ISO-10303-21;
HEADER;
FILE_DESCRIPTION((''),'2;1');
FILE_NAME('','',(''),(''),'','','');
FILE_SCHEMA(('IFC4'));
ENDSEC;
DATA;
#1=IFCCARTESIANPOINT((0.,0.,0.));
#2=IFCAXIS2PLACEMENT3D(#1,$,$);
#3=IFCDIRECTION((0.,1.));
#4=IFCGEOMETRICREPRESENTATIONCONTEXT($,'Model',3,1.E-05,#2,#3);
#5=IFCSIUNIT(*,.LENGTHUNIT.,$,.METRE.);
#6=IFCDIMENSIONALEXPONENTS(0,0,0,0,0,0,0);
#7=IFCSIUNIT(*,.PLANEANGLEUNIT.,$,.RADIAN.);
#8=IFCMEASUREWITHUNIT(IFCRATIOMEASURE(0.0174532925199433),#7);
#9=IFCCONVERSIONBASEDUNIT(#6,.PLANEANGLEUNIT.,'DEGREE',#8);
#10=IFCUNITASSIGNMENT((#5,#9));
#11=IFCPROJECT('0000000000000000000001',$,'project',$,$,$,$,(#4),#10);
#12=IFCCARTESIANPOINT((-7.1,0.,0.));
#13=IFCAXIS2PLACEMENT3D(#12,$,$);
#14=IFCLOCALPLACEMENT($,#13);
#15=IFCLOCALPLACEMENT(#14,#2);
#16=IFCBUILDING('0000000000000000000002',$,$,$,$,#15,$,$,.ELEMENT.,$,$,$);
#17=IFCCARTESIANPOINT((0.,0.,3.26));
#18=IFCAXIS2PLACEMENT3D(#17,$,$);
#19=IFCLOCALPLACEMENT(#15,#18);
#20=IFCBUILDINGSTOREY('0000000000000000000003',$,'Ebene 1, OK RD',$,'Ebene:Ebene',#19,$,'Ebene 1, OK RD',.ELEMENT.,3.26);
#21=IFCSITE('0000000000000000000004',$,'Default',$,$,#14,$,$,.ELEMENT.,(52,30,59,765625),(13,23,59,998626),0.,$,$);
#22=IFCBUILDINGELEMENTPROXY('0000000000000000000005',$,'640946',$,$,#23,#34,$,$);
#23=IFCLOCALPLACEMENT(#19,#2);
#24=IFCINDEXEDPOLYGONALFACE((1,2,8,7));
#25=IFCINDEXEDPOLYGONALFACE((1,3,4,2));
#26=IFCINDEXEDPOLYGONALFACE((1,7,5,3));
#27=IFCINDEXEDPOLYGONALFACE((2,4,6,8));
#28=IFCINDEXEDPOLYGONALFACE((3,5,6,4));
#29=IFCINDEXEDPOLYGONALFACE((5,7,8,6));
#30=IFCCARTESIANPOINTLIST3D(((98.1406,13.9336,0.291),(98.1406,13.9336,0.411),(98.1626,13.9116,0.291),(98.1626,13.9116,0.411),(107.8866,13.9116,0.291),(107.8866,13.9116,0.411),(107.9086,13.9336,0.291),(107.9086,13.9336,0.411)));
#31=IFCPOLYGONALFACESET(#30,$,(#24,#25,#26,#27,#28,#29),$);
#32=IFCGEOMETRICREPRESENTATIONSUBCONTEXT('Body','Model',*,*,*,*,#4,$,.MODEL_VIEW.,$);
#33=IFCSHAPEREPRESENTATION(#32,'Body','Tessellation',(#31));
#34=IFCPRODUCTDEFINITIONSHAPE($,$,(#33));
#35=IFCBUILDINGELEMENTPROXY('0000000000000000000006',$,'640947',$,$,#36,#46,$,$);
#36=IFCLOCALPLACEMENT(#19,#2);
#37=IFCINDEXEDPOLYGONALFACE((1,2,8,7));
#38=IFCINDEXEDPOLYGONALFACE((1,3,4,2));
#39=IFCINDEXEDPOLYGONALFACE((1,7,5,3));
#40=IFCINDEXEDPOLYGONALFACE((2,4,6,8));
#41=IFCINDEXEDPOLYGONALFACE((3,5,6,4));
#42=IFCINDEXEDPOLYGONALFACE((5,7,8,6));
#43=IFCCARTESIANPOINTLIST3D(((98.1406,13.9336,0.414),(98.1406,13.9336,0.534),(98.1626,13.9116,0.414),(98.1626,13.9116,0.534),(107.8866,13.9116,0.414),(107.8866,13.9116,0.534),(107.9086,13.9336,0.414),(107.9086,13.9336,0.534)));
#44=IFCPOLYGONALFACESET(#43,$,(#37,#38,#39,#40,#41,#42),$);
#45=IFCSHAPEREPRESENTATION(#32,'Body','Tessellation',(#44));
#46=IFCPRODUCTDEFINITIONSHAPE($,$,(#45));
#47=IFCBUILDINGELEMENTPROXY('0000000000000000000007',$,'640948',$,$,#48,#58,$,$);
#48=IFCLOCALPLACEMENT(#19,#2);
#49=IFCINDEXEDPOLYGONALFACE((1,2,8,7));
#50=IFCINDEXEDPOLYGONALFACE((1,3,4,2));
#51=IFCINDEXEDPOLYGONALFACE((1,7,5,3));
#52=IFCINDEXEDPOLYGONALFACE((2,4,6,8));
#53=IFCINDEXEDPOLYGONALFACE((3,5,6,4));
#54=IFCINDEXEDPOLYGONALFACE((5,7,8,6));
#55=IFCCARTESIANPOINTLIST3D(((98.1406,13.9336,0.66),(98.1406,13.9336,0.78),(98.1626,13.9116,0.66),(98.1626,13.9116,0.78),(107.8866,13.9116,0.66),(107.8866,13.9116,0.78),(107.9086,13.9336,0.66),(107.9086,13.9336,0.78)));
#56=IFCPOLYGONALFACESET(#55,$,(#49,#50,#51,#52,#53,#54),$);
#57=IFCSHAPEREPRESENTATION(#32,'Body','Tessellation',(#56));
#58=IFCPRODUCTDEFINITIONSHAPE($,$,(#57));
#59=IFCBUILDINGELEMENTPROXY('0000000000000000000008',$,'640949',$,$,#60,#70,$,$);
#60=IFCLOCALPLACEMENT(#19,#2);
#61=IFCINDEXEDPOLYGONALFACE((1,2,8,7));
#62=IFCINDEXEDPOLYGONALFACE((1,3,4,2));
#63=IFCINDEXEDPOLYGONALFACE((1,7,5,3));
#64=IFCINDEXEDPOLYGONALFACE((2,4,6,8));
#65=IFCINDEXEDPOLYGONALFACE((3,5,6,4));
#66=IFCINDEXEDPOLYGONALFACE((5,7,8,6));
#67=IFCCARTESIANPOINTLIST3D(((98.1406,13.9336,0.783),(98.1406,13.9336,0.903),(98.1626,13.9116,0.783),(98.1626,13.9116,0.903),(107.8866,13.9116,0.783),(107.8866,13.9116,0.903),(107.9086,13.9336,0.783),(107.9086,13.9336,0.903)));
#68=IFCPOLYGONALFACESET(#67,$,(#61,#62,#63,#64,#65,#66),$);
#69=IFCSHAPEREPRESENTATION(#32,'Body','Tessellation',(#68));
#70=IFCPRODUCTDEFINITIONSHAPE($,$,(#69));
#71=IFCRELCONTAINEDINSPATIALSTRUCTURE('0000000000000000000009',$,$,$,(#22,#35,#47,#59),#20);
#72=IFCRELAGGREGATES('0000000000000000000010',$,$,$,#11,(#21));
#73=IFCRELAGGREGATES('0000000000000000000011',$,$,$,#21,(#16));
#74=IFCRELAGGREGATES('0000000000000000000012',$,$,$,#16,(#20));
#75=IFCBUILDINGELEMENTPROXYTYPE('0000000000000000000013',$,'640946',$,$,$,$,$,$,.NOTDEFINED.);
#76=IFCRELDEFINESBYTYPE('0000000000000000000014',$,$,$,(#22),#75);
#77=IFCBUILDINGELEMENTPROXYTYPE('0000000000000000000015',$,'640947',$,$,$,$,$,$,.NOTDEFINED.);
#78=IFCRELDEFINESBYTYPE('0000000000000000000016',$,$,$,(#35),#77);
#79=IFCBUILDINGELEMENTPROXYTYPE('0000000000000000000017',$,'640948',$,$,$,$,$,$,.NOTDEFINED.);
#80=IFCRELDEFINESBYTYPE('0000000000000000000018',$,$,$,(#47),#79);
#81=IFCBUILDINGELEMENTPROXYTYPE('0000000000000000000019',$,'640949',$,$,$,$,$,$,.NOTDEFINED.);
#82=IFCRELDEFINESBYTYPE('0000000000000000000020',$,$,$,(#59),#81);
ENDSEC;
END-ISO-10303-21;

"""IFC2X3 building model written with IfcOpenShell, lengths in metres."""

from ifc_helpers import new_model, entity, si_unit, converted_unit, direction, frame, origin, place, context, subcontext, project, spatial, polyline, outline, extrude, type_object, element, save


model = new_model("IFC2X3")

# Units and contexts
model_context = context("Model", 3, precision=1e-05, world=origin(), true_north=direction((0.0, 1.0)))
body_context = subcontext(model_context, "Body", "Model", "MODEL_VIEW")
ifc_project = project(units=[si_unit("LENGTHUNIT", "METRE"), converted_unit("PLANEANGLEUNIT", "DEGREE", entity("IfcRatioMeasure", 0.0174532925199433), si_unit("PLANEANGLEUNIT", "RADIAN"), dimensions=[0, 0, 0, 0, 0, 0, 0])], contexts=[model_context])

# Site, building, storey
site_placement = place(None, frame((-7.1, 0.0, 0.0)))
site = spatial("IfcSite", under=ifc_project, at=site_placement, Name="Default", CompositionType="ELEMENT", RefLatitude=(52, 30, 59, 765625), RefLongitude=(13, 23, 59, 998626), RefElevation=0.0)
building_placement = place(site_placement, origin())
building = spatial("IfcBuilding", under=site, at=building_placement, CompositionType="ELEMENT")
storey_placement = place(building_placement, frame((0.0, 0.0, 3.26)))
storey = spatial("IfcBuildingStorey", under=building, at=storey_placement, Name="Ebene 1, OK RD", ObjectType="Ebene:Ebene", LongName="Ebene 1, OK RD", CompositionType="ELEMENT", Elevation=3.26)

# Building element proxies
building_element_proxy_type_1 = type_object("IfcBuildingElementProxyType", Name="640946", PredefinedType="NOTDEFINED")
proxy_1_placement = place(storey_placement, origin())
element("IfcBuildingElementProxy", 1, at=proxy_1_placement, inside=storey, type_object=building_element_proxy_type_1, Name="640946", context=body_context, shape_type="SweptSolid", body=[
    extrude(outline(polyline([(-4.862, -0.011), (4.862, -0.011), (4.884, 0.011), (-4.884, 0.011), (-4.862, -0.011)])), frame((103.0246, 13.9226, 0.291)), (0.0, 0.0, 1.0), 0.12),
])
building_element_proxy_type_2 = type_object("IfcBuildingElementProxyType", Name="640947", PredefinedType="NOTDEFINED")
proxy_2_placement = place(storey_placement, origin())
element("IfcBuildingElementProxy", 2, at=proxy_2_placement, inside=storey, type_object=building_element_proxy_type_2, Name="640947", context=body_context, shape_type="SweptSolid", body=[
    extrude(outline(polyline([(-4.862, -0.011), (4.862, -0.011), (4.884, 0.011), (-4.884, 0.011), (-4.862, -0.011)])), frame((103.0246, 13.9226, 0.414)), (0.0, 0.0, 1.0), 0.12),
])
building_element_proxy_type_3 = type_object("IfcBuildingElementProxyType", Name="640948", PredefinedType="NOTDEFINED")
proxy_3_placement = place(storey_placement, origin())
element("IfcBuildingElementProxy", 3, at=proxy_3_placement, inside=storey, type_object=building_element_proxy_type_3, Name="640948", context=body_context, shape_type="SweptSolid", body=[
    extrude(outline(polyline([(-4.862, -0.011), (4.862, -0.011), (4.884, 0.011), (-4.884, 0.011), (-4.862, -0.011)])), frame((103.0246, 13.9226, 0.66)), (0.0, 0.0, 1.0), 0.12),
])
building_element_proxy_type_4 = type_object("IfcBuildingElementProxyType", Name="640949", PredefinedType="NOTDEFINED")
proxy_4_placement = place(storey_placement, origin())
element("IfcBuildingElementProxy", 4, at=proxy_4_placement, inside=storey, type_object=building_element_proxy_type_4, Name="640949", context=body_context, shape_type="SweptSolid", body=[
    extrude(outline(polyline([(-4.862, -0.011), (4.862, -0.011), (4.884, 0.011), (-4.884, 0.011), (-4.862, -0.011)])), frame((103.0246, 13.9226, 0.783)), (0.0, 0.0, 1.0), 0.12),
])

save(model, "model.ifc")
